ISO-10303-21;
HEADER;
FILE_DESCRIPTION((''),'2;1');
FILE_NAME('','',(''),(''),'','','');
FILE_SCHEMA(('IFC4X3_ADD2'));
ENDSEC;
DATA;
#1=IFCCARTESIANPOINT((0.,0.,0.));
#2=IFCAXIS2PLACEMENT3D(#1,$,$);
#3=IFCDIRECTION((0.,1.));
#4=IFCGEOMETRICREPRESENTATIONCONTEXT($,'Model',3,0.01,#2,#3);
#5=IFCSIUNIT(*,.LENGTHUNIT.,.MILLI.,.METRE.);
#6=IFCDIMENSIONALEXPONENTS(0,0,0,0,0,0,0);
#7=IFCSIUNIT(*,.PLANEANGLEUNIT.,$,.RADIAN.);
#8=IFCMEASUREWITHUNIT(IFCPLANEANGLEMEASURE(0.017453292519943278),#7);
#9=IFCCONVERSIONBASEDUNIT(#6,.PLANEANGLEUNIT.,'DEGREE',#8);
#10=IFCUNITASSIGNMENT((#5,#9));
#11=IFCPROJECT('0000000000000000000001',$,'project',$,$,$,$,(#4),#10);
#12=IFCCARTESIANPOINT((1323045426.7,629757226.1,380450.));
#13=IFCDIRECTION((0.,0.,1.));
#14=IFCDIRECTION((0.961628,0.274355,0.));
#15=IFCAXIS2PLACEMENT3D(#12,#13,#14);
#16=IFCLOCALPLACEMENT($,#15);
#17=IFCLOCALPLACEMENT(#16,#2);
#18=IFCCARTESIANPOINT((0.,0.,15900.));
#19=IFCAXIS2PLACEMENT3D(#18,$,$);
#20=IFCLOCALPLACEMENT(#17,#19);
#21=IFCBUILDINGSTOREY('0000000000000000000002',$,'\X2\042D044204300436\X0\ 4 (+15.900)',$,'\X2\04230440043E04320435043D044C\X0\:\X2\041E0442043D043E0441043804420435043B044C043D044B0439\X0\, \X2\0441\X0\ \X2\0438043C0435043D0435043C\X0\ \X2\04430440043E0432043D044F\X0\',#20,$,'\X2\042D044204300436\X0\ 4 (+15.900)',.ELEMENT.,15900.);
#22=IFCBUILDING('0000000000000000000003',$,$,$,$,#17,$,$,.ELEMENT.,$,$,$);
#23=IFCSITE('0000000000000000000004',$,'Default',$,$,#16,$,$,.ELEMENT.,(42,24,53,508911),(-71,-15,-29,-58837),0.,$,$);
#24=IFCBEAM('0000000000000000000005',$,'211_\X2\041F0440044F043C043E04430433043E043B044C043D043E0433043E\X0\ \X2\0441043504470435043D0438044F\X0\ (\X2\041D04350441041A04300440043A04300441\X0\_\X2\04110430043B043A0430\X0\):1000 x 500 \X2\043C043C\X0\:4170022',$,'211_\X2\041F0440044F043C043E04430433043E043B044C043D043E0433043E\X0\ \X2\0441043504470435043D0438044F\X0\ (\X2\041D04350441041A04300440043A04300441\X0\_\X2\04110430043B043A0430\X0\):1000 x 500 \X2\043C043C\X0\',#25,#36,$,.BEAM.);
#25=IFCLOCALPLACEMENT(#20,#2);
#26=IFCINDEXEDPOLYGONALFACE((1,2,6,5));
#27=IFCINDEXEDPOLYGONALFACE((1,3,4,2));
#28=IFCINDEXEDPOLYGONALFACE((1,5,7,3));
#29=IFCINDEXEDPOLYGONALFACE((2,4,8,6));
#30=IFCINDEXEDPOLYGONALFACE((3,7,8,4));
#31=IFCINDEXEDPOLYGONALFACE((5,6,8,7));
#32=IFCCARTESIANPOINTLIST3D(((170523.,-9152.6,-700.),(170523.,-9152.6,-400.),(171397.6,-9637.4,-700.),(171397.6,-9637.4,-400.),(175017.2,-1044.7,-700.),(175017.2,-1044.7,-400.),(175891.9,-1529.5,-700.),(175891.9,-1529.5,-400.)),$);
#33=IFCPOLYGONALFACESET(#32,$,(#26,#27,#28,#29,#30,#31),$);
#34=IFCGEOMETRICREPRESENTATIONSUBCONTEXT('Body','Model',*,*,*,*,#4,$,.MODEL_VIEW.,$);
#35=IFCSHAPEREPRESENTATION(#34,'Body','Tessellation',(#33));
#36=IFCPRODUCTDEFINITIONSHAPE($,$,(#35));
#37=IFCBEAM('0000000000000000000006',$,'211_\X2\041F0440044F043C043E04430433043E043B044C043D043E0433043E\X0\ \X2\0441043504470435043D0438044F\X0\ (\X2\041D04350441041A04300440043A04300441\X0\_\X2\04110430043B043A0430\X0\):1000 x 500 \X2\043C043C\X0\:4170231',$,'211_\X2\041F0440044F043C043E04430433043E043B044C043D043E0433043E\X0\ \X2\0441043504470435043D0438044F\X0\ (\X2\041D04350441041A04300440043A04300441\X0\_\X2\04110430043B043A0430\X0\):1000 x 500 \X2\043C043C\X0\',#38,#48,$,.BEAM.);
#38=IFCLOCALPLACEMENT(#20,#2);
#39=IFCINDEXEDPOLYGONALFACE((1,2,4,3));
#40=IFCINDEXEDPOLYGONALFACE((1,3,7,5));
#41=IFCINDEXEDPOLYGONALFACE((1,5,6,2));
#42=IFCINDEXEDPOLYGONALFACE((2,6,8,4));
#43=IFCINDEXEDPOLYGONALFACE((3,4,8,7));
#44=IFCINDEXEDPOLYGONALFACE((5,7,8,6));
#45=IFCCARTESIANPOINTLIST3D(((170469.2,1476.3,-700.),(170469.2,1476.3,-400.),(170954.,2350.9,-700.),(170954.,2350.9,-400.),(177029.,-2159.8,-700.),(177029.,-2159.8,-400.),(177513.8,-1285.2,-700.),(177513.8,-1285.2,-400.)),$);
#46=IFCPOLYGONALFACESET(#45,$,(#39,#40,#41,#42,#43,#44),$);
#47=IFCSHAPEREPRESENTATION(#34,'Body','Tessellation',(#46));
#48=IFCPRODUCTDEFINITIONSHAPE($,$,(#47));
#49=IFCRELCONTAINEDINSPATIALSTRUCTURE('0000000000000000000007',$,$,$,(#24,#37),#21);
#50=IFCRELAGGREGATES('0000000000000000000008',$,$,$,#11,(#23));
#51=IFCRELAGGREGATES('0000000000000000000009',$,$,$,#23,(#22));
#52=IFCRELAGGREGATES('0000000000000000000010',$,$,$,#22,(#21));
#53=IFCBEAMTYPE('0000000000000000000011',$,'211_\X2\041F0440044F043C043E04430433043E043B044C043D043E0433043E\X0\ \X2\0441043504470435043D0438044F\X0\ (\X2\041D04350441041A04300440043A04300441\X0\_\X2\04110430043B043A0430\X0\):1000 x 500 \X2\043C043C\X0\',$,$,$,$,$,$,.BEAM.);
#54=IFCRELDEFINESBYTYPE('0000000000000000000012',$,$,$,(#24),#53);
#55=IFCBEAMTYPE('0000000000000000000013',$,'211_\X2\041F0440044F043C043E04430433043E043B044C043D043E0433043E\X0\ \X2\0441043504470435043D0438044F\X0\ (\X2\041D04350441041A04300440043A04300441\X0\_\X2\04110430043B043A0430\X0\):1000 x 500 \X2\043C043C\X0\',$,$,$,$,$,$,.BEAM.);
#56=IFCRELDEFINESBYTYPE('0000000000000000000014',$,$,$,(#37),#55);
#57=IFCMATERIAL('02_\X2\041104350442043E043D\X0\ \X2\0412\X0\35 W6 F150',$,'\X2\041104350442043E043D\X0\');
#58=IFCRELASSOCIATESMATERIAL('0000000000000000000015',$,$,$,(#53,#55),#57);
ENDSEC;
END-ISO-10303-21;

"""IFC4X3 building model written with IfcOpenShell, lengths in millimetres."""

from ifc_helpers import new_model, entity, si_unit, converted_unit, direction, frame, frame_2d, origin, place, context, subcontext, project, spatial, rectangle, extrude, source, transform, mapped, material, material_profile, profile_set, type_object, type_shapes, element, save


model = new_model("IFC4X3")

# Units and contexts
model_context = context("Model", 3, precision=0.01, world=origin(), true_north=direction((0.0, 1.0)))
body_context = subcontext(model_context, "Body", "Model", "MODEL_VIEW")
ifc_project = project(units=[si_unit("LENGTHUNIT", "METRE", prefix="MILLI"), converted_unit("PLANEANGLEUNIT", "DEGREE", entity("IfcPlaneAngleMeasure", 0.017453292519943278), si_unit("PLANEANGLEUNIT", "RADIAN"), dimensions=[0, 0, 0, 0, 0, 0, 0])], contexts=[model_context])

# Site, building, storey
site_placement = place(None, frame((1323045426.7, 629757226.1, 380450.0), z_axis=(0.0, 0.0, 1.0), x_axis=(0.961628, 0.274355, 0.0)))
site = spatial("IfcSite", under=ifc_project, at=site_placement, Name="Default", CompositionType="ELEMENT", RefLatitude=(42, 24, 53, 508911), RefLongitude=(-71, -15, -29, -58837), RefElevation=0.0)
building_placement = place(site_placement, origin())
building = spatial("IfcBuilding", under=site, at=building_placement, CompositionType="ELEMENT")
storey_placement = place(building_placement, frame((0.0, 0.0, 15900.0)))
storey = spatial("IfcBuildingStorey", under=building, at=storey_placement, Name="Этаж 4 (+15.900)", ObjectType="Уровень:Относительный, с именем уровня", LongName="Этаж 4 (+15.900)", CompositionType="ELEMENT", Elevation=15900.0)

# Beams
ifc_material = material(Name="02_Бетон В35 W6 F150", Category="Бетон")
ifc_material_profile_1 = material_profile(ifc_material, rectangle(XDim=300.0, YDim=1000.0, at=frame_2d((0.0, 0.0), x_axis=(1.0, 0.0))), Name="1000 x 500 мм")
ifc_profile_set_1 = profile_set([ifc_material_profile_1], Name="1000 x 500 мм")
beam_type_1 = type_object("IfcBeamType", Name="211_Прямоугольного сечения (НесКаркас_Балка):1000 x 500 мм", PredefinedType="BEAM", material=ifc_profile_set_1)
shared_shape_1 = source(origin(), body_context, "Body", "SweptSolid", [
    extrude(rectangle(XDim=300.0, YDim=1000.0, at=frame_2d((0.0, 0.0), x_axis=(1.0, 0.0))), frame((175454.6, -1287.1, 15350.0), z_axis=(-0.48481, -0.87462, 0.0), x_axis=(0.0, 0.0, -1.0)), (0.0, 0.0, 1.0), 9270.1),
])
type_shapes(beam_type_1, [shared_shape_1])
beam_1_placement = place(storey_placement, frame((0.0, 0.0, -15900.0)))
element("IfcBeam", 1, at=beam_1_placement, inside=storey, type_object=beam_type_1, Name="211_Прямоугольного сечения (НесКаркас_Балка):1000 x 500 мм:4170022", ObjectType="211_Прямоугольного сечения (НесКаркас_Балка):1000 x 500 мм", PredefinedType="BEAM", context=body_context, shape_type="MappedRepresentation", body=[
    mapped(shared_shape_1, transform((0.0, 0.0, 0.0), scale=1.0)),
])
beam_type_2 = type_object("IfcBeamType", Name="211_Прямоугольного сечения (НесКаркас_Балка):1000 x 500 мм", PredefinedType="BEAM", material=ifc_profile_set_1)
shared_shape_2 = source(origin(), body_context, "Body", "SweptSolid", [
    extrude(rectangle(XDim=300.0, YDim=1000.0, at=frame_2d((0.0, 0.0), x_axis=(1.0, 0.0))), frame((177271.4, -1722.5, 15350.0), z_axis=(-0.87462, 0.48481, 0.0), x_axis=(0.0, 0.0, 1.0)), (0.0, 0.0, 1.0), 7500.1),
])
type_shapes(beam_type_2, [shared_shape_2])
beam_2_placement = place(storey_placement, frame((0.0, 0.0, -15900.0)))
element("IfcBeam", 2, at=beam_2_placement, inside=storey, type_object=beam_type_2, Name="211_Прямоугольного сечения (НесКаркас_Балка):1000 x 500 мм:4170231", ObjectType="211_Прямоугольного сечения (НесКаркас_Балка):1000 x 500 мм", PredefinedType="BEAM", context=body_context, shape_type="MappedRepresentation", body=[
    mapped(shared_shape_2, transform((0.0, 0.0, 0.0), scale=1.0)),
])

save(model, "model.ifc")
